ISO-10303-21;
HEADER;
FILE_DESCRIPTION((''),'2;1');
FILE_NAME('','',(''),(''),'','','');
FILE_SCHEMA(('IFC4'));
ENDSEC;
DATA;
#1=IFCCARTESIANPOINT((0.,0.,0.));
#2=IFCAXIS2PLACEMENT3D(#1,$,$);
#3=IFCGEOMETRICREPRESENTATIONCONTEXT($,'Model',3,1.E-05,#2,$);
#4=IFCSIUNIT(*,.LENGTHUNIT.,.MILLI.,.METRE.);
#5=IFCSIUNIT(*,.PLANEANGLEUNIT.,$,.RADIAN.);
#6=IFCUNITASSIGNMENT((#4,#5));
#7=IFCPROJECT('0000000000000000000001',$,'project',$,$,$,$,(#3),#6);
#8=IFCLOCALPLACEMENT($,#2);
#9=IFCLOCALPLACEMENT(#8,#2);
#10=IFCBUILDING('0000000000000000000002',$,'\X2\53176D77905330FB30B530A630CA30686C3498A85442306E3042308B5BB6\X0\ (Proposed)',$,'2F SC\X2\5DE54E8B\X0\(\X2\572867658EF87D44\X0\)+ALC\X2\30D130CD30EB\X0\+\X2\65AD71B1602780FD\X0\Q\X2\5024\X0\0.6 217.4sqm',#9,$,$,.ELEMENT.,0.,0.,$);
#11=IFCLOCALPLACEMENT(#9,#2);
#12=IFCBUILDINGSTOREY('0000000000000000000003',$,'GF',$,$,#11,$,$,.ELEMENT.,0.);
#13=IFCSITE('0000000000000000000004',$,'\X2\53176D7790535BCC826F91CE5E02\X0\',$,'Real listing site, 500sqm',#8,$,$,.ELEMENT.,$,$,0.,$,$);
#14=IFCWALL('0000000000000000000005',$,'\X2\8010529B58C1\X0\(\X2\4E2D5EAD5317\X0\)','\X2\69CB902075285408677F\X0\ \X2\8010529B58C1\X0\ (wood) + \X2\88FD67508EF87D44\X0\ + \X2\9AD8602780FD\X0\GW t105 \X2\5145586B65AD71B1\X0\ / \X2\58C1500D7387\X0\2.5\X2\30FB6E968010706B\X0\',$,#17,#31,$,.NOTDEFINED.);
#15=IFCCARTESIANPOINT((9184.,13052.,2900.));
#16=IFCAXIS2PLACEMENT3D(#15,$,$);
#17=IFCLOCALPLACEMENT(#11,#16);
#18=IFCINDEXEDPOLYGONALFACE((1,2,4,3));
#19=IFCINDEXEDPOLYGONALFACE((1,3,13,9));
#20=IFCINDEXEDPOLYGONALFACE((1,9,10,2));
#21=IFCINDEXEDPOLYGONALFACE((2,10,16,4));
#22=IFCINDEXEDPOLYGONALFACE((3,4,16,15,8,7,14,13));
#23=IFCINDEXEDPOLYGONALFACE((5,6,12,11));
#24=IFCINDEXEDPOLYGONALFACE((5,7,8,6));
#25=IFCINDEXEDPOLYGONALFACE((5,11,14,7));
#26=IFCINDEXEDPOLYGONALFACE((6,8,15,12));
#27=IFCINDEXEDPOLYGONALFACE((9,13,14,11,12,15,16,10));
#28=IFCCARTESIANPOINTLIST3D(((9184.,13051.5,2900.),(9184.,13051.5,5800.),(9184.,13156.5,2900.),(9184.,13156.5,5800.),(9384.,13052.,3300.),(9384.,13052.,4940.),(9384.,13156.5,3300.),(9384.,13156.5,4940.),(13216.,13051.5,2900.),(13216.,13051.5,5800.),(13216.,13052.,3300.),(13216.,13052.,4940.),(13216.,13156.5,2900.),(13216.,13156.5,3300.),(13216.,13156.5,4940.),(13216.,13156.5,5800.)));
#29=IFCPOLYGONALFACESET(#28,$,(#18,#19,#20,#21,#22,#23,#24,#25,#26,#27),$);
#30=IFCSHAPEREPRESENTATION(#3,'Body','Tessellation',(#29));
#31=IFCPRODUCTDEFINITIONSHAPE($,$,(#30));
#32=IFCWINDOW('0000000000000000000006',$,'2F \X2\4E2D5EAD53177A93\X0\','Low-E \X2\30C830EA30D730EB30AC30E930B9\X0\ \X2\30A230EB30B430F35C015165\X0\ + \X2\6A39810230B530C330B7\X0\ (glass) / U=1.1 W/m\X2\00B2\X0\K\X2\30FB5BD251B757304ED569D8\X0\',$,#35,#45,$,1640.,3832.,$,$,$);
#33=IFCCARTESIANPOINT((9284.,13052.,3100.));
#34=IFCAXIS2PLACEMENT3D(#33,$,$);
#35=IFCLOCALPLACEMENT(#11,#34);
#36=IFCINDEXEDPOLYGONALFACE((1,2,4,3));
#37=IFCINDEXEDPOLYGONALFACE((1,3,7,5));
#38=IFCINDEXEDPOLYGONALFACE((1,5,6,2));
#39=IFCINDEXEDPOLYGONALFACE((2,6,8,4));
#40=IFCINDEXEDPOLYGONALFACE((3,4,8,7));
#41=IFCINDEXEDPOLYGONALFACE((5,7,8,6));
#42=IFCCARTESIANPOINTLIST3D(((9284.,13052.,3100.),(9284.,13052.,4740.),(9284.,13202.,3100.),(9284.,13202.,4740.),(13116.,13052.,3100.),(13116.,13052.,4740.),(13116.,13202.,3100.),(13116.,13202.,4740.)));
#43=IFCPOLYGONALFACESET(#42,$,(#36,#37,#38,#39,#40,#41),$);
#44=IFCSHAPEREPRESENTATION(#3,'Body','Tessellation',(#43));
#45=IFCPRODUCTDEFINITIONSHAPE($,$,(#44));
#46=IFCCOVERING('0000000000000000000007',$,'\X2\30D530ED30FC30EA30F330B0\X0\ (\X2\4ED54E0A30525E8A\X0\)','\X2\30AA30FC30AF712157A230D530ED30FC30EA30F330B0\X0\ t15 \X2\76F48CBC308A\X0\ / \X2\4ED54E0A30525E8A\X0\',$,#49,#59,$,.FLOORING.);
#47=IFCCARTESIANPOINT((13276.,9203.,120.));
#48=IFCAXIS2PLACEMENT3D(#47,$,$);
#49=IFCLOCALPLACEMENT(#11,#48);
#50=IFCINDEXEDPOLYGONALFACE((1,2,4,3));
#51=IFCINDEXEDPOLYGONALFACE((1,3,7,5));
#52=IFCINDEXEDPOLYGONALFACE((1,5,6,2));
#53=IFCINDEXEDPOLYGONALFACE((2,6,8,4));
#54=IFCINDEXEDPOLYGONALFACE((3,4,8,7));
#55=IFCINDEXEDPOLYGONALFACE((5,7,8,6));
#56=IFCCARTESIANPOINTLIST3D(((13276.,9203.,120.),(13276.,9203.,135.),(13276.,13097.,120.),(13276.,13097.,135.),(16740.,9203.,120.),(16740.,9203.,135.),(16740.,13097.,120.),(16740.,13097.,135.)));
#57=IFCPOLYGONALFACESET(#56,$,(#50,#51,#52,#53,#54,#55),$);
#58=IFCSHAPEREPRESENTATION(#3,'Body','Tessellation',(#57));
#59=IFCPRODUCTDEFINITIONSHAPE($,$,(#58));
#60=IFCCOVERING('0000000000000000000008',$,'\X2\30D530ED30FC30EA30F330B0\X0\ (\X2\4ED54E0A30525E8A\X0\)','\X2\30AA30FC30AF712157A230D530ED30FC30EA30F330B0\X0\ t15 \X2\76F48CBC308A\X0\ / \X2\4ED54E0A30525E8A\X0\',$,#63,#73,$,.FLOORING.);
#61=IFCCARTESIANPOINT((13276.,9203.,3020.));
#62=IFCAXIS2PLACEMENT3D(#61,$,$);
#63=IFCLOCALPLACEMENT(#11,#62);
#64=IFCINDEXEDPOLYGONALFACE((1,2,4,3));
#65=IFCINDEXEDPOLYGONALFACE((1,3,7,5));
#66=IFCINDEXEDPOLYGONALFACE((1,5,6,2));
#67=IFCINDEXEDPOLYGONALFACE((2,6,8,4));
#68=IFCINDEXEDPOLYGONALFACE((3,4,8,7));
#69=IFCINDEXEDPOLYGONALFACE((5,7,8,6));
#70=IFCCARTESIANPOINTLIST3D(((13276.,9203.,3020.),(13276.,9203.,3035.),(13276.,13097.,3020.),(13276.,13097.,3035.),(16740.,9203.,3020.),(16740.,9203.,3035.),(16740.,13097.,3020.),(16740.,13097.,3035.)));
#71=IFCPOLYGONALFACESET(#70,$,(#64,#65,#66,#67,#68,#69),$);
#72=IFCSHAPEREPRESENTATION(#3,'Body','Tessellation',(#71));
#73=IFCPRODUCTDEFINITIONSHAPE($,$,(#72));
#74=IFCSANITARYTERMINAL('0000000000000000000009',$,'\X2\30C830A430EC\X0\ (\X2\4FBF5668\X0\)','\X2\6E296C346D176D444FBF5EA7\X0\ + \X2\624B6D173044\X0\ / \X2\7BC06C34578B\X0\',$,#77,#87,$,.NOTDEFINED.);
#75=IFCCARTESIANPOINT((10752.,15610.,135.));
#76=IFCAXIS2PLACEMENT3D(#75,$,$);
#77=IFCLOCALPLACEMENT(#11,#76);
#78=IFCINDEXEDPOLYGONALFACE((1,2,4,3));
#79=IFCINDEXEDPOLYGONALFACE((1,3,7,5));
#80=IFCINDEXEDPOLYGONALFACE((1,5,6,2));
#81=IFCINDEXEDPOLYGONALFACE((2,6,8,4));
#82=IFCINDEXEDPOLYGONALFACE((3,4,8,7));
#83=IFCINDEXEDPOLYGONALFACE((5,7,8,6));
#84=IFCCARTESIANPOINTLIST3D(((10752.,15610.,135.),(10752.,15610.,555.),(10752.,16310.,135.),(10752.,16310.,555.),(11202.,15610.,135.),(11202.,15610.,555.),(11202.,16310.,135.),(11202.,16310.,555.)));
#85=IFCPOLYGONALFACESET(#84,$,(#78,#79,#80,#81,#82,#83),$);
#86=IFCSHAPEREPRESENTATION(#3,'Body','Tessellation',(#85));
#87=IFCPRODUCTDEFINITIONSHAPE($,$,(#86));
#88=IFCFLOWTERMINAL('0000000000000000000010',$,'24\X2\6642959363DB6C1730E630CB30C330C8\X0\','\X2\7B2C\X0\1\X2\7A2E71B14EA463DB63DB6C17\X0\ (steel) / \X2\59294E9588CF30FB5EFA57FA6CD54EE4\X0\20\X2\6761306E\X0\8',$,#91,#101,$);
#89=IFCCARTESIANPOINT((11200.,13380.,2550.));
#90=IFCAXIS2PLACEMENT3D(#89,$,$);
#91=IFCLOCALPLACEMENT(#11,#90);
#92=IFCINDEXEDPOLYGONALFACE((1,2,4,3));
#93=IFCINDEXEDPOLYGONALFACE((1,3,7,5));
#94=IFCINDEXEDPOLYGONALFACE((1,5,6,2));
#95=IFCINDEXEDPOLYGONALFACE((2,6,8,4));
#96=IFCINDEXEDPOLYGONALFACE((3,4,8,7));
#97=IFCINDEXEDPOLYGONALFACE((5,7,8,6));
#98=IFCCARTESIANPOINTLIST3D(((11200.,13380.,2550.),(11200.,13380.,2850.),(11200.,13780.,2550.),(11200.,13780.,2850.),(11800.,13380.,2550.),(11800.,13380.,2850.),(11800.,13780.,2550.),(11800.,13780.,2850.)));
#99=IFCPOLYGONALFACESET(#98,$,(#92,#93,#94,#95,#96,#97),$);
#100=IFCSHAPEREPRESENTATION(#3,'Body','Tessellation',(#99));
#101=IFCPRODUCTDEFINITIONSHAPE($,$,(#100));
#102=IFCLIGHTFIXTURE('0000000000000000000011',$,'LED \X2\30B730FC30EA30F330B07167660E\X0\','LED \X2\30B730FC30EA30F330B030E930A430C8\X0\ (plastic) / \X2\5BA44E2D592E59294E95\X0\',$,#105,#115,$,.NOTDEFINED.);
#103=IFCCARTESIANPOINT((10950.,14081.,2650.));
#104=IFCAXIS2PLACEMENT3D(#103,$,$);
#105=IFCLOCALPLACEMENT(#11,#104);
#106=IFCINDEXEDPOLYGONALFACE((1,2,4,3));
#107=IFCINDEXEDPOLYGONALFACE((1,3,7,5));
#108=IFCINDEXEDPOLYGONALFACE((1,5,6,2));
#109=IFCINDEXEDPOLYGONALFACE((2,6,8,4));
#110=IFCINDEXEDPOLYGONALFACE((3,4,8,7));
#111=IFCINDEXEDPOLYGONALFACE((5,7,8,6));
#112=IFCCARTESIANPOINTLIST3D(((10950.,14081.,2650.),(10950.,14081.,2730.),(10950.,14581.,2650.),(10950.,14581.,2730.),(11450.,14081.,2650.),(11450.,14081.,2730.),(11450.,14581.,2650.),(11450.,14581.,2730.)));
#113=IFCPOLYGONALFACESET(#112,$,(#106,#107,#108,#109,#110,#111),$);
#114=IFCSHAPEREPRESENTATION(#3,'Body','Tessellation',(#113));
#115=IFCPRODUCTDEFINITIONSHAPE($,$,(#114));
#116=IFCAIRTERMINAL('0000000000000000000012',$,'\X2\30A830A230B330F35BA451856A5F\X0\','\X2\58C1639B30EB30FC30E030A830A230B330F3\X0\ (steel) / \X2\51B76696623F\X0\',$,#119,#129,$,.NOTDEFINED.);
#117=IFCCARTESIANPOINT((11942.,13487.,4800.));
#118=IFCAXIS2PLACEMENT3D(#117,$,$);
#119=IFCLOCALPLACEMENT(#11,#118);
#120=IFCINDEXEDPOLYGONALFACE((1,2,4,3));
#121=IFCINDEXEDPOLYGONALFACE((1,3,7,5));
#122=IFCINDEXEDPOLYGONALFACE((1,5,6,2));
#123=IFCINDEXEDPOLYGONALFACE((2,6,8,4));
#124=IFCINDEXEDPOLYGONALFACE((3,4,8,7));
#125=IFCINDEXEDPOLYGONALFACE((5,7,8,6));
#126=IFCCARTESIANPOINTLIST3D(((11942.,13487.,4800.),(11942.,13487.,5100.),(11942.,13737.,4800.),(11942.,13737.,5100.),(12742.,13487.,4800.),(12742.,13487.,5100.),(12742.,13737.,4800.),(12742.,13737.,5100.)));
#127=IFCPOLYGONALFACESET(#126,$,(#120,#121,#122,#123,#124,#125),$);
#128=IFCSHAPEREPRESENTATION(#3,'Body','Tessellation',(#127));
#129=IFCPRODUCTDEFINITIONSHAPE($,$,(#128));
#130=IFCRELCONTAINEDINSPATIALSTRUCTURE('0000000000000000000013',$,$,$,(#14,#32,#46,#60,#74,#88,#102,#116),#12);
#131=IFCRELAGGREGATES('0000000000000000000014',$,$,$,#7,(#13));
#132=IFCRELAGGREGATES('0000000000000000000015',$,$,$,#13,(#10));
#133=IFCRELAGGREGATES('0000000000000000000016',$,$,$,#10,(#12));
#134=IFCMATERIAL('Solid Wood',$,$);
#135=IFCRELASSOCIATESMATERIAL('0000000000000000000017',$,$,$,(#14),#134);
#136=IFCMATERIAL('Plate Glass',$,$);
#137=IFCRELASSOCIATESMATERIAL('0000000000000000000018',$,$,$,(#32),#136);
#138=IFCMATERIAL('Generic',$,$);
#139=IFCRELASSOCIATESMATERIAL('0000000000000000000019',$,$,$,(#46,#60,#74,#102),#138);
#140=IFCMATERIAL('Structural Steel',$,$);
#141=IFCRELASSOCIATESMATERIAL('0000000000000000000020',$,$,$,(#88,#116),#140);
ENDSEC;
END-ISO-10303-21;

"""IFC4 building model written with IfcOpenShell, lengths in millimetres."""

from ifc_helpers import new_model, si_unit, frame, frame_2d, origin, place, context, project, spatial, rectangle, extrude, material, element, fill, save


model = new_model("IFC4")

# Units and contexts
model_context = context("Model", 3, precision=1e-05, world=origin())
ifc_project = project(units=[si_unit("LENGTHUNIT", "METRE", prefix="MILLI"), si_unit("PLANEANGLEUNIT", "RADIAN")], contexts=[model_context])

# Site, building, storey
site_placement = place(None, origin())
site = spatial("IfcSite", under=ifc_project, at=site_placement, Name="北海道富良野市", ObjectType="Real listing site, 500sqm", CompositionType="ELEMENT", RefElevation=0.0)
building_placement = place(site_placement, origin())
building = spatial("IfcBuilding", under=site, at=building_placement, Name="北海道・サウナと水風呂のある家 (Proposed)", ObjectType="2F SC工事(在来軸組)+ALCパネル+断熱性能Q値0.6 217.4sqm", CompositionType="ELEMENT", ElevationOfRefHeight=0.0, ElevationOfTerrain=0.0)
storey_placement = place(building_placement, origin())
storey = spatial("IfcBuildingStorey", under=building, at=storey_placement, Name="GF", CompositionType="ELEMENT", Elevation=0.0)

# Shared definitions
ifc_material_1 = material(Name="Solid Wood")

# Shared definitions
ifc_material_2 = material(Name="Plate Glass")

# Wall, opening, window
wall_1_placement = place(storey_placement, frame((9184.0, 13052.0, 2900.0)))
wall_1 = element("IfcWall", 1, at=wall_1_placement, inside=storey, material=ifc_material_1, Name="耐力壁(中庭北)", Description="構造用合板 耐力壁 (wood) + 製材軸組 + 高性能GW t105 充填断熱 / 壁倍率2.5・準耐火", PredefinedType="NOTDEFINED", context=model_context, shape_type="SweptSolid", body=[
    extrude(rectangle(XDim=4032.0, YDim=105.0, at=frame_2d((2016.0, 52.0))), frame((9184.0, 13052.0, 2900.0)), (0.0, 0.0, 1.0), 2900.0),
])
opening_1_placement = place(storey_placement, frame((9284.0, 13052.0, 3100.0)))
opening_1 = element("IfcOpeningElement", 2, at=opening_1_placement, cuts=wall_1, PredefinedType="NOTDEFINED", context=model_context, shape_type="SweptSolid", body=[
    extrude(rectangle(XDim=3832.0, YDim=150.0, at=frame_2d((1916.0, 75.0))), frame((9284.0, 13052.0, 3100.0)), (0.0, 0.0, 1.0), 1640.0),
])
window_1_placement = place(storey_placement, frame((9284.0, 13052.0, 3100.0)))
window_1 = element("IfcWindow", 3, at=window_1_placement, inside=storey, material=ifc_material_2, Name="2F 中庭北窓", Description="Low-E トリプルガラス アルゴン封入 + 樹脂サッシ (glass) / U=1.1 W/m²K・寒冷地仕様", OverallHeight=1640.0, OverallWidth=3832.0, context=model_context, shape_type="SweptSolid", body=[
    extrude(rectangle(XDim=3832.0, YDim=150.0, at=frame_2d((1916.0, 75.0))), frame((9284.0, 13052.0, 3100.0)), (0.0, 0.0, 1.0), 1640.0),
])
fill(opening_1, window_1)

# Coverings
ifc_material_3 = material(Name="Generic")
covering_1_placement = place(storey_placement, frame((13276.0, 9203.0, 120.0)))
element("IfcCovering", 4, at=covering_1_placement, inside=storey, material=ifc_material_3, Name="フローリング (仕上げ床)", Description="オーク無垢フローリング t15 直貼り / 仕上げ床", PredefinedType="FLOORING", context=model_context, shape_type="SweptSolid", body=[
    extrude(rectangle(XDim=3464.0, YDim=3894.0, at=frame_2d((1732.0, 1947.0))), frame((13276.0, 9203.0, 120.0)), (0.0, 0.0, 1.0), 15.0),
])
covering_2_placement = place(storey_placement, frame((13276.0, 9203.0, 3020.0)))
element("IfcCovering", 5, at=covering_2_placement, inside=storey, material=ifc_material_3, Name="フローリング (仕上げ床)", Description="オーク無垢フローリング t15 直貼り / 仕上げ床", PredefinedType="FLOORING", context=model_context, shape_type="SweptSolid", body=[
    extrude(rectangle(XDim=3464.0, YDim=3894.0, at=frame_2d((1732.0, 1947.0))), frame((13276.0, 9203.0, 3020.0)), (0.0, 0.0, 1.0), 15.0),
])

# Sanitary terminal
sanitary_terminal_placement = place(storey_placement, frame((10752.0, 15610.0, 135.0)))
element("IfcSanitaryTerminal", 6, at=sanitary_terminal_placement, inside=storey, material=ifc_material_3, Name="トイレ (便器)", Description="温水洗浄便座 + 手洗い / 節水型", PredefinedType="NOTDEFINED", context=model_context, shape_type="SweptSolid", body=[
    extrude(rectangle(XDim=450.0, YDim=700.0, at=frame_2d((225.0, 350.0))), frame((10752.0, 15610.0, 135.0)), (0.0, 0.0, 1.0), 420.0),
])

# Flow terminal
ifc_material_4 = material(Name="Structural Steel")
flow_terminal_placement = place(storey_placement, frame((11200.0, 13380.0, 2550.0)))
element("IfcFlowTerminal", 7, at=flow_terminal_placement, inside=storey, material=ifc_material_4, Name="24時間換気ユニット", Description="第1種熱交換換気 (steel) / 天井裏・建基法令20条の8", context=model_context, shape_type="SweptSolid", body=[
    extrude(rectangle(XDim=600.0, YDim=400.0, at=frame_2d((300.0, 200.0))), frame((11200.0, 13380.0, 2550.0)), (0.0, 0.0, 1.0), 300.0),
])

# Light fixture
light_fixture_placement = place(storey_placement, frame((10950.0, 14081.0, 2650.0)))
element("IfcLightFixture", 8, at=light_fixture_placement, inside=storey, material=ifc_material_3, Name="LED シーリング照明", Description="LED シーリングライト (plastic) / 室中央天井", PredefinedType="NOTDEFINED", context=model_context, shape_type="SweptSolid", body=[
    extrude(rectangle(XDim=500.0, YDim=500.0, at=frame_2d((250.0, 250.0))), frame((10950.0, 14081.0, 2650.0)), (0.0, 0.0, 1.0), 80.0),
])

# Air terminal
air_terminal_placement = place(storey_placement, frame((11942.0, 13487.0, 4800.0)))
element("IfcAirTerminal", 9, at=air_terminal_placement, inside=storey, material=ifc_material_4, Name="エアコン室内機", Description="壁掛ルームエアコン (steel) / 冷暖房", PredefinedType="NOTDEFINED", context=model_context, shape_type="SweptSolid", body=[
    extrude(rectangle(XDim=800.0, YDim=250.0, at=frame_2d((400.0, 125.0))), frame((11942.0, 13487.0, 4800.0)), (0.0, 0.0, 1.0), 300.0),
])

save(model, "model.ifc")
